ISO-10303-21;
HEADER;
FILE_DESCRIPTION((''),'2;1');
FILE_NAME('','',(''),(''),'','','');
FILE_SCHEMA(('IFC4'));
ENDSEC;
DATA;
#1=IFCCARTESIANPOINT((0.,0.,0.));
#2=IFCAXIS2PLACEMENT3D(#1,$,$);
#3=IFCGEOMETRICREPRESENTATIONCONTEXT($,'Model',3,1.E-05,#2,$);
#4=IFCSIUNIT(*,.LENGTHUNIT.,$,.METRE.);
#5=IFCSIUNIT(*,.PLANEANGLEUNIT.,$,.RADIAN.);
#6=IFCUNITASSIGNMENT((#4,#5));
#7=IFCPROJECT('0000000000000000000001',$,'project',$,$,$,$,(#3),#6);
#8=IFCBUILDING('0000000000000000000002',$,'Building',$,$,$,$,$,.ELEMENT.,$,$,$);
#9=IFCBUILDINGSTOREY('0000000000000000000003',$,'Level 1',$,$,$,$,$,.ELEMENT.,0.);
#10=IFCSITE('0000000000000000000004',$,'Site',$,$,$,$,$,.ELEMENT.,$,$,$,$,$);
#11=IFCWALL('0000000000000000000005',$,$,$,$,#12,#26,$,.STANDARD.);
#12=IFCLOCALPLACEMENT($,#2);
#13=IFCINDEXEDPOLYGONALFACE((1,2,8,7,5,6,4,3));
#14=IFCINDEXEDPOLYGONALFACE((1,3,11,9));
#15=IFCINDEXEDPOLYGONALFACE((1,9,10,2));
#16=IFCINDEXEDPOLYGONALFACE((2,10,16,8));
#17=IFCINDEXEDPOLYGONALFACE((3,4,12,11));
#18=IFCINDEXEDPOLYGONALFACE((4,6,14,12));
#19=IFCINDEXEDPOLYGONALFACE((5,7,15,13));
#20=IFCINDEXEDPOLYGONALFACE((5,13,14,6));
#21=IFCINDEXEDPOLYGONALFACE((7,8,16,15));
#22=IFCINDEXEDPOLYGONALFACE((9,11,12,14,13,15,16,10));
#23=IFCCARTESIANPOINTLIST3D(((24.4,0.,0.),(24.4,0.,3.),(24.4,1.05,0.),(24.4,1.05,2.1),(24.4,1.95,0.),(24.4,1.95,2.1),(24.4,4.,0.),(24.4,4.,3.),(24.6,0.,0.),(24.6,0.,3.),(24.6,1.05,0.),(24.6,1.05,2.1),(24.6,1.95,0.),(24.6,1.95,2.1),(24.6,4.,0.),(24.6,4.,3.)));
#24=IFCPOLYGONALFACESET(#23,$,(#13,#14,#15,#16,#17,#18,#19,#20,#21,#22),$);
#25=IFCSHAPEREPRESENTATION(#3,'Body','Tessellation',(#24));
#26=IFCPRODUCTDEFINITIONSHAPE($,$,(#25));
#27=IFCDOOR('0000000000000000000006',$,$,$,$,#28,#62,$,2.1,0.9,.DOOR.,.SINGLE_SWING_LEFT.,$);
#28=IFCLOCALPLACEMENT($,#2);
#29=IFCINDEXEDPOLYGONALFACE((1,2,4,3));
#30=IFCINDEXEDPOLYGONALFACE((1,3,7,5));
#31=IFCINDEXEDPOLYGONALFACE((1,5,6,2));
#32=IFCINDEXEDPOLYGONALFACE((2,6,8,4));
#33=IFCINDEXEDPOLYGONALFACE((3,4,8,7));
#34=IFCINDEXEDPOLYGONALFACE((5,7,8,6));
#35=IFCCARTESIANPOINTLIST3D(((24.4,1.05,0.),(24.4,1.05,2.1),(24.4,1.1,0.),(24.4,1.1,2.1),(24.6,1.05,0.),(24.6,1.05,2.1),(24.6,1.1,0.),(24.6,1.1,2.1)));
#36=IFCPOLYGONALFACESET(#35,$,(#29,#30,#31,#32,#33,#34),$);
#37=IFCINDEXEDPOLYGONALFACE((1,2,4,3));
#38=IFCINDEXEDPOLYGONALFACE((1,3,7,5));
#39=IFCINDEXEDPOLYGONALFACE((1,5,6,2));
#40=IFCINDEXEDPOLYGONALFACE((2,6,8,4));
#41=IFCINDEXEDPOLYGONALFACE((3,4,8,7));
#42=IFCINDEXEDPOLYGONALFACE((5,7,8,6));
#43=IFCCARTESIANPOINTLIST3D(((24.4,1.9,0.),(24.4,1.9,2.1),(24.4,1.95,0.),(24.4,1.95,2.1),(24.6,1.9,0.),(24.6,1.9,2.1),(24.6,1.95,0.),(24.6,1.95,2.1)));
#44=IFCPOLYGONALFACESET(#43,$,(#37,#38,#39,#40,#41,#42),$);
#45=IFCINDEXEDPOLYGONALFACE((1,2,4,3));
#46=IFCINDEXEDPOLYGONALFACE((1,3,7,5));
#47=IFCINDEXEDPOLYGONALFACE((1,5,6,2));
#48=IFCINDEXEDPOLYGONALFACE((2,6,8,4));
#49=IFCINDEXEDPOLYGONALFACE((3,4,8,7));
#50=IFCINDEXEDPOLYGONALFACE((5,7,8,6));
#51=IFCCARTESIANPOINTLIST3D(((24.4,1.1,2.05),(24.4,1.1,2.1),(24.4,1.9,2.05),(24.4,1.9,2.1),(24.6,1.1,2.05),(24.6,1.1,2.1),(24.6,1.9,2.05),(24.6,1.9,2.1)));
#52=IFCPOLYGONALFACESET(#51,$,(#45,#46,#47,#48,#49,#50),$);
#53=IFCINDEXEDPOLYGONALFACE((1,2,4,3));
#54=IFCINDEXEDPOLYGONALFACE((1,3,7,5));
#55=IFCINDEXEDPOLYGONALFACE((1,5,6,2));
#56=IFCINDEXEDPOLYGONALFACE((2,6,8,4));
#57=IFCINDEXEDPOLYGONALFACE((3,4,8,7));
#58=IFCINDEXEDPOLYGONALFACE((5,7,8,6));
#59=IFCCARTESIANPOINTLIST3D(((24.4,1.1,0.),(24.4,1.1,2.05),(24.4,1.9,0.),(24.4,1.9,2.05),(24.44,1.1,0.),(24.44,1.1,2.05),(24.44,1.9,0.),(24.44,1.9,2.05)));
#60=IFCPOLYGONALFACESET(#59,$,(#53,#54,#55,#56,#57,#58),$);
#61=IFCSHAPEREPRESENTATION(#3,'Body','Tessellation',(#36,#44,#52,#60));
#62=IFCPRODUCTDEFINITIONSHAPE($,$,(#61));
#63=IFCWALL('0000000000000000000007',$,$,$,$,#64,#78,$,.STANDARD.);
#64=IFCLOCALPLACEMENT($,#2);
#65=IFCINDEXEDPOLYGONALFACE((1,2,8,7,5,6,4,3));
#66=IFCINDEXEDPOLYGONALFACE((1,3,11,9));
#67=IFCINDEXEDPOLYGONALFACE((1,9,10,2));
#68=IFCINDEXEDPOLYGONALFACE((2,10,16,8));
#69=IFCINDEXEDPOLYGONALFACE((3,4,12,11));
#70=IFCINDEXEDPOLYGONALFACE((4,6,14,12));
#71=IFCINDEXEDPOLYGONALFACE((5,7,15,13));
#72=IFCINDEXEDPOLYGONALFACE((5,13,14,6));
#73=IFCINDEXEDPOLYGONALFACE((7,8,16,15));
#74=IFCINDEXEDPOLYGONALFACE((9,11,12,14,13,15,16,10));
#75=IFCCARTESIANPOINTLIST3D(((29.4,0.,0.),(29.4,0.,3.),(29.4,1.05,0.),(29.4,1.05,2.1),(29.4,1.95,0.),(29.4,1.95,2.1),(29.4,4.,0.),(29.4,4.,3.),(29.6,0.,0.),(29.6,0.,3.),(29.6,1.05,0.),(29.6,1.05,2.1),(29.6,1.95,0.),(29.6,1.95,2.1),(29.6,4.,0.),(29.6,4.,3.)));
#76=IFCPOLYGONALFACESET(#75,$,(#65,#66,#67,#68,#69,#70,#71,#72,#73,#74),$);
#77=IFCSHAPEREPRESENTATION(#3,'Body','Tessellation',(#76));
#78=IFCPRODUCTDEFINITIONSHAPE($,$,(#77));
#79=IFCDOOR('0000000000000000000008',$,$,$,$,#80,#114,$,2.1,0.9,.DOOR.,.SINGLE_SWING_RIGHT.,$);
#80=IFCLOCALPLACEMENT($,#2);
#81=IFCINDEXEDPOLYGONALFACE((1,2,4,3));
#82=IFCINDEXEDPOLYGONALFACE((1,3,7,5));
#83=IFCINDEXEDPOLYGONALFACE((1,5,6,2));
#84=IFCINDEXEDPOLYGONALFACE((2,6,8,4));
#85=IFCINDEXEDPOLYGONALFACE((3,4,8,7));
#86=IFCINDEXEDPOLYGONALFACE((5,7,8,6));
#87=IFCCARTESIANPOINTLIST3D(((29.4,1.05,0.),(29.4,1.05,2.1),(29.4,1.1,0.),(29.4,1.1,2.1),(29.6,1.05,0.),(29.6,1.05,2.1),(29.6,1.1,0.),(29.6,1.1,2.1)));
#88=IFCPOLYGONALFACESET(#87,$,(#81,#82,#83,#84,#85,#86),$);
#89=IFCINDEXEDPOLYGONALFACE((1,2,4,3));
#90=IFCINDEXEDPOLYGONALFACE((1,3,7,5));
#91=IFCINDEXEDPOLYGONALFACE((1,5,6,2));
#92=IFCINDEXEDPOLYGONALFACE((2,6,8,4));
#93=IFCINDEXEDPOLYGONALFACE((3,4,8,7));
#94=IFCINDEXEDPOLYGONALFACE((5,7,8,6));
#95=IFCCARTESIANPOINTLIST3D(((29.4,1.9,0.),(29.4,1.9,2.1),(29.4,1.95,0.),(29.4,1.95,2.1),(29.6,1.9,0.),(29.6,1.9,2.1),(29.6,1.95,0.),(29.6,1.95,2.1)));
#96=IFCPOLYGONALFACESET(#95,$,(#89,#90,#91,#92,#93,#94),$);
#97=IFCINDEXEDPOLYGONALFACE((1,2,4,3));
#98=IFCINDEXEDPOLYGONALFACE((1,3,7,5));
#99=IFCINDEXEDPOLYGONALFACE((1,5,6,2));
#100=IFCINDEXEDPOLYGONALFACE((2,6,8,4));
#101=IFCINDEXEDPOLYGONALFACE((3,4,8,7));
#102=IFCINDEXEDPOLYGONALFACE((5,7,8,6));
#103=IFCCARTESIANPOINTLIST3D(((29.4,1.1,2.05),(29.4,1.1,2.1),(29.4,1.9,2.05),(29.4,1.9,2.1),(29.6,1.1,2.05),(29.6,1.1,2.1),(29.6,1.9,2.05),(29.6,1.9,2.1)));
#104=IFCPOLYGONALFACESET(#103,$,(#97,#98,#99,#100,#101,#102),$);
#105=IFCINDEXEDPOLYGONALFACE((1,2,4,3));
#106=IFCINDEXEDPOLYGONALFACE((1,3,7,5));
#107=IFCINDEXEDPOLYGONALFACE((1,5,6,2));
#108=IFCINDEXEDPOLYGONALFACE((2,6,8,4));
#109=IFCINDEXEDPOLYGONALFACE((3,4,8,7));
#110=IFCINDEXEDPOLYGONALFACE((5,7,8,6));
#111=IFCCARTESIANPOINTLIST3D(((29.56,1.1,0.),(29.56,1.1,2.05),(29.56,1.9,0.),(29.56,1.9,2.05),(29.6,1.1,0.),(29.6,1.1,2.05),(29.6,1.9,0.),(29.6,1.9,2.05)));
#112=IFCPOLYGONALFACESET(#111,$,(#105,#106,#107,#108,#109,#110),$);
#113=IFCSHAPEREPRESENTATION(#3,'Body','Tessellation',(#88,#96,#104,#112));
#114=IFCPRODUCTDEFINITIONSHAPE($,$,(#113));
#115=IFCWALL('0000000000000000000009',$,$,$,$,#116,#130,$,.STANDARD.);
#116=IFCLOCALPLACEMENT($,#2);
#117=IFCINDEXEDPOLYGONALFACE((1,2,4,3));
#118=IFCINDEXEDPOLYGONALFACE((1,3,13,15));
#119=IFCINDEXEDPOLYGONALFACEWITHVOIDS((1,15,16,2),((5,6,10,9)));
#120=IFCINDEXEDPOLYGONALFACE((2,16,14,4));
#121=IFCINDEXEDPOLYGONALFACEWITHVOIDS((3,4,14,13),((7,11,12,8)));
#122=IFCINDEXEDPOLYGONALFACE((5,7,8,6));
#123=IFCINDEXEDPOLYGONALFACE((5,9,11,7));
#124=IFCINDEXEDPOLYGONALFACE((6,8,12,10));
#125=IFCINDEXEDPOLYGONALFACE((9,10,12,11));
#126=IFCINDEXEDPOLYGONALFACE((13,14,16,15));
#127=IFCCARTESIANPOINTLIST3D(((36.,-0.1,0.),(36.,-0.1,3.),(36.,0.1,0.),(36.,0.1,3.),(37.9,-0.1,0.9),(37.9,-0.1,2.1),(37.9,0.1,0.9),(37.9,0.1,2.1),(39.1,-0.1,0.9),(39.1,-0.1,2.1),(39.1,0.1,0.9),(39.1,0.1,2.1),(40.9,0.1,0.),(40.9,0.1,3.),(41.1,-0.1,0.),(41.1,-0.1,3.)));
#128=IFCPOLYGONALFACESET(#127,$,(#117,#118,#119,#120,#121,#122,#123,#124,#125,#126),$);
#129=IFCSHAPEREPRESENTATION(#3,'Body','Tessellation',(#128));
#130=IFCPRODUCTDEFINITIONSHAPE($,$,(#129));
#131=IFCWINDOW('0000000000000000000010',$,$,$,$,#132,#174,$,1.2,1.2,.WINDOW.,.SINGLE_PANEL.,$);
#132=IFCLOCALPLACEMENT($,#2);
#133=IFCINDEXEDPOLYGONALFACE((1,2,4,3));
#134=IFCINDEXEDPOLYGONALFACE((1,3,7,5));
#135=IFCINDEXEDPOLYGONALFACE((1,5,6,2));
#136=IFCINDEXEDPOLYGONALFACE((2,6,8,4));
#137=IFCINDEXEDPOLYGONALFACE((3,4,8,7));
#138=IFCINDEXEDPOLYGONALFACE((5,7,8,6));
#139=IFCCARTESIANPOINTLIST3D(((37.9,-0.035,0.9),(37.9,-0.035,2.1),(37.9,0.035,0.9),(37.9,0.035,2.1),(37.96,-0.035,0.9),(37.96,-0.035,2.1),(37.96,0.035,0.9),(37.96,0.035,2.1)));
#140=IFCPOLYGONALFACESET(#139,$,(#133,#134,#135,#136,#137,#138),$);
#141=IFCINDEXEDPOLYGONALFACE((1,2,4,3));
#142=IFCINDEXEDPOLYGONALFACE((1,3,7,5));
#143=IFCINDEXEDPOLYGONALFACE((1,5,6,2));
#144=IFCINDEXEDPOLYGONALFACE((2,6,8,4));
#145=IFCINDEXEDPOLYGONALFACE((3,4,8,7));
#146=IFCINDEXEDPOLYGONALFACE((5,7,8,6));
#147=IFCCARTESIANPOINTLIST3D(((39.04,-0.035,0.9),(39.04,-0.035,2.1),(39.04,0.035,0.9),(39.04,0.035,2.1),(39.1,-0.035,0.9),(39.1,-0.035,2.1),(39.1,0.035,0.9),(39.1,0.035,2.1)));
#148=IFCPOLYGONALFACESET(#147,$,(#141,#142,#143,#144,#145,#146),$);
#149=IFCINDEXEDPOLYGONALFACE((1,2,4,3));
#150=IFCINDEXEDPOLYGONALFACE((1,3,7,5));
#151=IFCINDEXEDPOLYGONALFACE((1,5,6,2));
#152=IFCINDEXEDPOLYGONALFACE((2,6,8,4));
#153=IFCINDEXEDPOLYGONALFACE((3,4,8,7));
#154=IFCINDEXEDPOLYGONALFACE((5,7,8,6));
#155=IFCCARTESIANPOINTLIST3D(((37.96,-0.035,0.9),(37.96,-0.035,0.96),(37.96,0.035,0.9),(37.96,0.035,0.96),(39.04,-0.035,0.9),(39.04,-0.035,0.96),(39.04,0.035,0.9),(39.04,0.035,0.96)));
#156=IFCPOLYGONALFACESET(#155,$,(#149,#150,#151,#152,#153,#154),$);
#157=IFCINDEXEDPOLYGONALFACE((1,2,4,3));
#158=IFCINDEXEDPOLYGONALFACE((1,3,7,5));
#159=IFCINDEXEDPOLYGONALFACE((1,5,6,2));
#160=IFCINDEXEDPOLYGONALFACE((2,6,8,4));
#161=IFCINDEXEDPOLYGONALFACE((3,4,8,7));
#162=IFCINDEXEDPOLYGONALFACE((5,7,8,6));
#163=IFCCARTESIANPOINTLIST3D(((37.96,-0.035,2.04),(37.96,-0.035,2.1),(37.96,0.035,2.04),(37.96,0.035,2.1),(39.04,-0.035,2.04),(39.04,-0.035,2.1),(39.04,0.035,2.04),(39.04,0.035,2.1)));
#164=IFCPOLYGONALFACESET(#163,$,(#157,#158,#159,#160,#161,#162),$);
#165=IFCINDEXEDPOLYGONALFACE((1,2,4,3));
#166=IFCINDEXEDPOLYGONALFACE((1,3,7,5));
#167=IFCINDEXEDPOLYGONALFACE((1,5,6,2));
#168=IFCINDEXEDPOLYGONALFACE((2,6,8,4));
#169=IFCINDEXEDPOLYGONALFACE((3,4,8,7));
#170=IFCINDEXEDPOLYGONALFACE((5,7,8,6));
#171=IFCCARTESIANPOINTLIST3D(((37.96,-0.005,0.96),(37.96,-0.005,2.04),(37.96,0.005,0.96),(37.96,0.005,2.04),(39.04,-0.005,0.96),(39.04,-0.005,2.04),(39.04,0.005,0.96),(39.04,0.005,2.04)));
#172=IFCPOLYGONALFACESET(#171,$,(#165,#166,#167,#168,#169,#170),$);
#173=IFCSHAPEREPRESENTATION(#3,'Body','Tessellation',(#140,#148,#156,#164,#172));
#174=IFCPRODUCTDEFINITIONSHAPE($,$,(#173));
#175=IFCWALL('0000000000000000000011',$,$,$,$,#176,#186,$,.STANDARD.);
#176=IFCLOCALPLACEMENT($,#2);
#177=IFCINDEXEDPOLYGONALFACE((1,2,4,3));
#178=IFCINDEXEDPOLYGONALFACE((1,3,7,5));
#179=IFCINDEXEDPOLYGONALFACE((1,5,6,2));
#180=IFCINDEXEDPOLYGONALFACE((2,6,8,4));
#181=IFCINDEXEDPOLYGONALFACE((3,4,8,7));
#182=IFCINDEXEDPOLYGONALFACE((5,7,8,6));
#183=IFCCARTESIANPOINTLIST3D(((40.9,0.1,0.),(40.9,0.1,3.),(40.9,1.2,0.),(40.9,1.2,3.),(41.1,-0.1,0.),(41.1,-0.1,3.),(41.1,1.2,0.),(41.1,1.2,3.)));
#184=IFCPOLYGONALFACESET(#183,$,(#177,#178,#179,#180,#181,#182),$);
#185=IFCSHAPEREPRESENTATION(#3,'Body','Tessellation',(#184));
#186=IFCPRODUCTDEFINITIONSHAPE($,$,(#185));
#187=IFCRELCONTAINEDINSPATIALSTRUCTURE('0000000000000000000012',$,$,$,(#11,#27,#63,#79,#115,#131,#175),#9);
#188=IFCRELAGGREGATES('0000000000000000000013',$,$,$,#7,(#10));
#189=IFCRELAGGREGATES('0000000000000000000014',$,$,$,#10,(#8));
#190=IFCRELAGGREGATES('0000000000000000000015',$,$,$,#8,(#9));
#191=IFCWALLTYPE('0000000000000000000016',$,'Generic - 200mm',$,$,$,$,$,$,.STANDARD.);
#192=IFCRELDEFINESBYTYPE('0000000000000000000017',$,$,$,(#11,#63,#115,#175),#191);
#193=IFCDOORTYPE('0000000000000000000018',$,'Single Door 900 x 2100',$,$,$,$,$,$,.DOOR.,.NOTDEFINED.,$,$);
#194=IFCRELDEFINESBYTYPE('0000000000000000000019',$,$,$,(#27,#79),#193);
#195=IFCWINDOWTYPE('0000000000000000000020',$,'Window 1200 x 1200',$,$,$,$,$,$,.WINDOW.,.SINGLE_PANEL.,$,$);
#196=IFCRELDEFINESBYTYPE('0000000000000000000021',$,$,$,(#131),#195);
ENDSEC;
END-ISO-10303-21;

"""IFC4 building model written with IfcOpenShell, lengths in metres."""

from ifc_helpers import new_model, si_unit, frame, frame_2d, origin, origin_with_axes, origin_2d, place, context, project, spatial, polyline, rectangle, outline, extrude, type_object, element, fill, save


model = new_model("IFC4")

# Units and contexts
model_context = context("Model", 3, precision=1e-05, world=origin())
ifc_project = project(units=[si_unit("LENGTHUNIT", "METRE"), si_unit("PLANEANGLEUNIT", "RADIAN")], contexts=[model_context])

# Site, building, storey
site = spatial("IfcSite", under=ifc_project, Name="Site", CompositionType="ELEMENT")
building = spatial("IfcBuilding", under=site, Name="Building", CompositionType="ELEMENT")
storey = spatial("IfcBuildingStorey", under=building, Name="Level 1", CompositionType="ELEMENT", Elevation=0.0)

# Walls, openings, doors
wall_type = type_object("IfcWallType", Name="Generic - 200mm", PredefinedType="STANDARD")
wall_1_placement = place(None, frame((24.5, 0.0, 0.0), z_axis=(0.0, 0.0, 1.0), x_axis=(0.0, 1.0, 0.0)))
wall_1 = element("IfcWall", 1, at=wall_1_placement, inside=storey, type_object=wall_type, PredefinedType="STANDARD", context=model_context, shape_type="SweptSolid", body=[
    extrude(rectangle(XDim=4.0, YDim=0.2, at=frame_2d((2.0, 0.0))), origin(), (0.0, 0.0, 1.0), 3.0),
])
opening_1_placement = place(wall_1_placement, frame((1.5, 0.0, 0.0), z_axis=(0.0, 0.0, 1.0), x_axis=(1.0, 0.0, 0.0)))
opening_1 = element("IfcOpeningElement", 2, at=opening_1_placement, cuts=wall_1, PredefinedType="OPENING", context=model_context, shape_type="SweptSolid", body=[
    extrude(rectangle(XDim=0.9, YDim=0.202, at=origin_2d()), origin(), (0.0, 0.0, 1.0), 2.1),
])
door_type = type_object("IfcDoorType", Name="Single Door 900 x 2100", OperationType="NOTDEFINED", PredefinedType="DOOR")
door_1_placement = place(opening_1_placement, origin_with_axes())
door_1 = element("IfcDoor", 3, at=door_1_placement, inside=storey, type_object=door_type, OperationType="SINGLE_SWING_LEFT", OverallHeight=2.1, OverallWidth=0.9, PredefinedType="DOOR", context=model_context, shape_type="SweptSolid", body=[
    extrude(rectangle(XDim=0.05, YDim=0.2, at=frame_2d((-0.425, 0.0))), origin(), (0.0, 0.0, 1.0), 2.1),
    extrude(rectangle(XDim=0.05, YDim=0.2, at=frame_2d((0.425, 0.0))), origin(), (0.0, 0.0, 1.0), 2.1),
    extrude(rectangle(XDim=0.8, YDim=0.2, at=origin_2d()), frame((0.0, 0.0, 2.05)), (0.0, 0.0, 1.0), 0.05),
    extrude(rectangle(XDim=0.8, YDim=0.04, at=frame_2d((0.0, 0.08))), origin(), (0.0, 0.0, 1.0), 2.05),
])
fill(opening_1, door_1)
wall_2_placement = place(None, frame((29.5, 0.0, 0.0), z_axis=(0.0, 0.0, 1.0), x_axis=(0.0, 1.0, 0.0)))
wall_2 = element("IfcWall", 4, at=wall_2_placement, inside=storey, type_object=wall_type, PredefinedType="STANDARD", context=model_context, shape_type="SweptSolid", body=[
    extrude(rectangle(XDim=4.0, YDim=0.2, at=frame_2d((2.0, 0.0))), origin(), (0.0, 0.0, 1.0), 3.0),
])
opening_2_placement = place(wall_2_placement, frame((1.5, 0.0, 0.0), z_axis=(0.0, 0.0, 1.0), x_axis=(1.0, 0.0, 0.0)))
opening_2 = element("IfcOpeningElement", 5, at=opening_2_placement, cuts=wall_2, PredefinedType="OPENING", context=model_context, shape_type="SweptSolid", body=[
    extrude(rectangle(XDim=0.9, YDim=0.202, at=origin_2d()), origin(), (0.0, 0.0, 1.0), 2.1),
])
door_2_placement = place(opening_2_placement, origin_with_axes())
door_2 = element("IfcDoor", 6, at=door_2_placement, inside=storey, type_object=door_type, OperationType="SINGLE_SWING_RIGHT", OverallHeight=2.1, OverallWidth=0.9, PredefinedType="DOOR", context=model_context, shape_type="SweptSolid", body=[
    extrude(rectangle(XDim=0.05, YDim=0.2, at=frame_2d((-0.425, 0.0))), origin(), (0.0, 0.0, 1.0), 2.1),
    extrude(rectangle(XDim=0.05, YDim=0.2, at=frame_2d((0.425, 0.0))), origin(), (0.0, 0.0, 1.0), 2.1),
    extrude(rectangle(XDim=0.8, YDim=0.2, at=origin_2d()), frame((0.0, 0.0, 2.05)), (0.0, 0.0, 1.0), 0.05),
    extrude(rectangle(XDim=0.8, YDim=0.04, at=frame_2d((0.0, -0.08))), origin(), (0.0, 0.0, 1.0), 2.05),
])
fill(opening_2, door_2)

# Wall, opening, window
wall_3_placement = place(None, frame((36.0, 0.0, 0.0), z_axis=(0.0, 0.0, 1.0), x_axis=(1.0, 0.0, 0.0)))
wall_3 = element("IfcWall", 7, at=wall_3_placement, inside=storey, type_object=wall_type, PredefinedType="STANDARD", context=model_context, shape_type="SweptSolid", body=[
    extrude(outline(polyline([(0.0, -0.1), (5.1, -0.1), (4.9, 0.1), (0.0, 0.1), (0.0, -0.1)])), origin(), (0.0, 0.0, 1.0), 3.0),
])
opening_3_placement = place(wall_3_placement, frame((2.5, 0.0, 0.9), z_axis=(0.0, 0.0, 1.0), x_axis=(1.0, 0.0, 0.0)))
opening_3 = element("IfcOpeningElement", 8, at=opening_3_placement, cuts=wall_3, PredefinedType="OPENING", context=model_context, shape_type="SweptSolid", body=[
    extrude(rectangle(XDim=1.2, YDim=0.202, at=origin_2d()), origin(), (0.0, 0.0, 1.0), 1.2),
])
window_type = type_object("IfcWindowType", Name="Window 1200 x 1200", PartitioningType="SINGLE_PANEL", PredefinedType="WINDOW")
window_1_placement = place(opening_3_placement, origin_with_axes())
window_1 = element("IfcWindow", 9, at=window_1_placement, inside=storey, type_object=window_type, OverallHeight=1.2, OverallWidth=1.2, PartitioningType="SINGLE_PANEL", PredefinedType="WINDOW", context=model_context, shape_type="SweptSolid", body=[
    extrude(rectangle(XDim=0.06, YDim=0.07, at=frame_2d((-0.57, 0.0))), origin(), (0.0, 0.0, 1.0), 1.2),
    extrude(rectangle(XDim=0.06, YDim=0.07, at=frame_2d((0.57, 0.0))), origin(), (0.0, 0.0, 1.0), 1.2),
    extrude(rectangle(XDim=1.08, YDim=0.07, at=origin_2d()), origin(), (0.0, 0.0, 1.0), 0.06),
    extrude(rectangle(XDim=1.08, YDim=0.07, at=origin_2d()), frame((0.0, 0.0, 1.14)), (0.0, 0.0, 1.0), 0.06),
    extrude(rectangle(XDim=1.08, YDim=0.01, at=origin_2d()), frame((0.0, 0.0, 0.06)), (0.0, 0.0, 1.0), 1.08),
])
fill(opening_3, window_1)

# Wall
wall_4_placement = place(None, frame((41.0, 0.0, 0.0), z_axis=(0.0, 0.0, 1.0), x_axis=(0.0, 1.0, 0.0)))
element("IfcWall", 10, at=wall_4_placement, inside=storey, type_object=wall_type, PredefinedType="STANDARD", context=model_context, shape_type="SweptSolid", body=[
    extrude(outline(polyline([(-0.1, -0.1), (1.2, -0.1), (1.2, 0.1), (0.1, 0.1), (-0.1, -0.1)])), origin(), (0.0, 0.0, 1.0), 3.0),
])

save(model, "model.ifc")
